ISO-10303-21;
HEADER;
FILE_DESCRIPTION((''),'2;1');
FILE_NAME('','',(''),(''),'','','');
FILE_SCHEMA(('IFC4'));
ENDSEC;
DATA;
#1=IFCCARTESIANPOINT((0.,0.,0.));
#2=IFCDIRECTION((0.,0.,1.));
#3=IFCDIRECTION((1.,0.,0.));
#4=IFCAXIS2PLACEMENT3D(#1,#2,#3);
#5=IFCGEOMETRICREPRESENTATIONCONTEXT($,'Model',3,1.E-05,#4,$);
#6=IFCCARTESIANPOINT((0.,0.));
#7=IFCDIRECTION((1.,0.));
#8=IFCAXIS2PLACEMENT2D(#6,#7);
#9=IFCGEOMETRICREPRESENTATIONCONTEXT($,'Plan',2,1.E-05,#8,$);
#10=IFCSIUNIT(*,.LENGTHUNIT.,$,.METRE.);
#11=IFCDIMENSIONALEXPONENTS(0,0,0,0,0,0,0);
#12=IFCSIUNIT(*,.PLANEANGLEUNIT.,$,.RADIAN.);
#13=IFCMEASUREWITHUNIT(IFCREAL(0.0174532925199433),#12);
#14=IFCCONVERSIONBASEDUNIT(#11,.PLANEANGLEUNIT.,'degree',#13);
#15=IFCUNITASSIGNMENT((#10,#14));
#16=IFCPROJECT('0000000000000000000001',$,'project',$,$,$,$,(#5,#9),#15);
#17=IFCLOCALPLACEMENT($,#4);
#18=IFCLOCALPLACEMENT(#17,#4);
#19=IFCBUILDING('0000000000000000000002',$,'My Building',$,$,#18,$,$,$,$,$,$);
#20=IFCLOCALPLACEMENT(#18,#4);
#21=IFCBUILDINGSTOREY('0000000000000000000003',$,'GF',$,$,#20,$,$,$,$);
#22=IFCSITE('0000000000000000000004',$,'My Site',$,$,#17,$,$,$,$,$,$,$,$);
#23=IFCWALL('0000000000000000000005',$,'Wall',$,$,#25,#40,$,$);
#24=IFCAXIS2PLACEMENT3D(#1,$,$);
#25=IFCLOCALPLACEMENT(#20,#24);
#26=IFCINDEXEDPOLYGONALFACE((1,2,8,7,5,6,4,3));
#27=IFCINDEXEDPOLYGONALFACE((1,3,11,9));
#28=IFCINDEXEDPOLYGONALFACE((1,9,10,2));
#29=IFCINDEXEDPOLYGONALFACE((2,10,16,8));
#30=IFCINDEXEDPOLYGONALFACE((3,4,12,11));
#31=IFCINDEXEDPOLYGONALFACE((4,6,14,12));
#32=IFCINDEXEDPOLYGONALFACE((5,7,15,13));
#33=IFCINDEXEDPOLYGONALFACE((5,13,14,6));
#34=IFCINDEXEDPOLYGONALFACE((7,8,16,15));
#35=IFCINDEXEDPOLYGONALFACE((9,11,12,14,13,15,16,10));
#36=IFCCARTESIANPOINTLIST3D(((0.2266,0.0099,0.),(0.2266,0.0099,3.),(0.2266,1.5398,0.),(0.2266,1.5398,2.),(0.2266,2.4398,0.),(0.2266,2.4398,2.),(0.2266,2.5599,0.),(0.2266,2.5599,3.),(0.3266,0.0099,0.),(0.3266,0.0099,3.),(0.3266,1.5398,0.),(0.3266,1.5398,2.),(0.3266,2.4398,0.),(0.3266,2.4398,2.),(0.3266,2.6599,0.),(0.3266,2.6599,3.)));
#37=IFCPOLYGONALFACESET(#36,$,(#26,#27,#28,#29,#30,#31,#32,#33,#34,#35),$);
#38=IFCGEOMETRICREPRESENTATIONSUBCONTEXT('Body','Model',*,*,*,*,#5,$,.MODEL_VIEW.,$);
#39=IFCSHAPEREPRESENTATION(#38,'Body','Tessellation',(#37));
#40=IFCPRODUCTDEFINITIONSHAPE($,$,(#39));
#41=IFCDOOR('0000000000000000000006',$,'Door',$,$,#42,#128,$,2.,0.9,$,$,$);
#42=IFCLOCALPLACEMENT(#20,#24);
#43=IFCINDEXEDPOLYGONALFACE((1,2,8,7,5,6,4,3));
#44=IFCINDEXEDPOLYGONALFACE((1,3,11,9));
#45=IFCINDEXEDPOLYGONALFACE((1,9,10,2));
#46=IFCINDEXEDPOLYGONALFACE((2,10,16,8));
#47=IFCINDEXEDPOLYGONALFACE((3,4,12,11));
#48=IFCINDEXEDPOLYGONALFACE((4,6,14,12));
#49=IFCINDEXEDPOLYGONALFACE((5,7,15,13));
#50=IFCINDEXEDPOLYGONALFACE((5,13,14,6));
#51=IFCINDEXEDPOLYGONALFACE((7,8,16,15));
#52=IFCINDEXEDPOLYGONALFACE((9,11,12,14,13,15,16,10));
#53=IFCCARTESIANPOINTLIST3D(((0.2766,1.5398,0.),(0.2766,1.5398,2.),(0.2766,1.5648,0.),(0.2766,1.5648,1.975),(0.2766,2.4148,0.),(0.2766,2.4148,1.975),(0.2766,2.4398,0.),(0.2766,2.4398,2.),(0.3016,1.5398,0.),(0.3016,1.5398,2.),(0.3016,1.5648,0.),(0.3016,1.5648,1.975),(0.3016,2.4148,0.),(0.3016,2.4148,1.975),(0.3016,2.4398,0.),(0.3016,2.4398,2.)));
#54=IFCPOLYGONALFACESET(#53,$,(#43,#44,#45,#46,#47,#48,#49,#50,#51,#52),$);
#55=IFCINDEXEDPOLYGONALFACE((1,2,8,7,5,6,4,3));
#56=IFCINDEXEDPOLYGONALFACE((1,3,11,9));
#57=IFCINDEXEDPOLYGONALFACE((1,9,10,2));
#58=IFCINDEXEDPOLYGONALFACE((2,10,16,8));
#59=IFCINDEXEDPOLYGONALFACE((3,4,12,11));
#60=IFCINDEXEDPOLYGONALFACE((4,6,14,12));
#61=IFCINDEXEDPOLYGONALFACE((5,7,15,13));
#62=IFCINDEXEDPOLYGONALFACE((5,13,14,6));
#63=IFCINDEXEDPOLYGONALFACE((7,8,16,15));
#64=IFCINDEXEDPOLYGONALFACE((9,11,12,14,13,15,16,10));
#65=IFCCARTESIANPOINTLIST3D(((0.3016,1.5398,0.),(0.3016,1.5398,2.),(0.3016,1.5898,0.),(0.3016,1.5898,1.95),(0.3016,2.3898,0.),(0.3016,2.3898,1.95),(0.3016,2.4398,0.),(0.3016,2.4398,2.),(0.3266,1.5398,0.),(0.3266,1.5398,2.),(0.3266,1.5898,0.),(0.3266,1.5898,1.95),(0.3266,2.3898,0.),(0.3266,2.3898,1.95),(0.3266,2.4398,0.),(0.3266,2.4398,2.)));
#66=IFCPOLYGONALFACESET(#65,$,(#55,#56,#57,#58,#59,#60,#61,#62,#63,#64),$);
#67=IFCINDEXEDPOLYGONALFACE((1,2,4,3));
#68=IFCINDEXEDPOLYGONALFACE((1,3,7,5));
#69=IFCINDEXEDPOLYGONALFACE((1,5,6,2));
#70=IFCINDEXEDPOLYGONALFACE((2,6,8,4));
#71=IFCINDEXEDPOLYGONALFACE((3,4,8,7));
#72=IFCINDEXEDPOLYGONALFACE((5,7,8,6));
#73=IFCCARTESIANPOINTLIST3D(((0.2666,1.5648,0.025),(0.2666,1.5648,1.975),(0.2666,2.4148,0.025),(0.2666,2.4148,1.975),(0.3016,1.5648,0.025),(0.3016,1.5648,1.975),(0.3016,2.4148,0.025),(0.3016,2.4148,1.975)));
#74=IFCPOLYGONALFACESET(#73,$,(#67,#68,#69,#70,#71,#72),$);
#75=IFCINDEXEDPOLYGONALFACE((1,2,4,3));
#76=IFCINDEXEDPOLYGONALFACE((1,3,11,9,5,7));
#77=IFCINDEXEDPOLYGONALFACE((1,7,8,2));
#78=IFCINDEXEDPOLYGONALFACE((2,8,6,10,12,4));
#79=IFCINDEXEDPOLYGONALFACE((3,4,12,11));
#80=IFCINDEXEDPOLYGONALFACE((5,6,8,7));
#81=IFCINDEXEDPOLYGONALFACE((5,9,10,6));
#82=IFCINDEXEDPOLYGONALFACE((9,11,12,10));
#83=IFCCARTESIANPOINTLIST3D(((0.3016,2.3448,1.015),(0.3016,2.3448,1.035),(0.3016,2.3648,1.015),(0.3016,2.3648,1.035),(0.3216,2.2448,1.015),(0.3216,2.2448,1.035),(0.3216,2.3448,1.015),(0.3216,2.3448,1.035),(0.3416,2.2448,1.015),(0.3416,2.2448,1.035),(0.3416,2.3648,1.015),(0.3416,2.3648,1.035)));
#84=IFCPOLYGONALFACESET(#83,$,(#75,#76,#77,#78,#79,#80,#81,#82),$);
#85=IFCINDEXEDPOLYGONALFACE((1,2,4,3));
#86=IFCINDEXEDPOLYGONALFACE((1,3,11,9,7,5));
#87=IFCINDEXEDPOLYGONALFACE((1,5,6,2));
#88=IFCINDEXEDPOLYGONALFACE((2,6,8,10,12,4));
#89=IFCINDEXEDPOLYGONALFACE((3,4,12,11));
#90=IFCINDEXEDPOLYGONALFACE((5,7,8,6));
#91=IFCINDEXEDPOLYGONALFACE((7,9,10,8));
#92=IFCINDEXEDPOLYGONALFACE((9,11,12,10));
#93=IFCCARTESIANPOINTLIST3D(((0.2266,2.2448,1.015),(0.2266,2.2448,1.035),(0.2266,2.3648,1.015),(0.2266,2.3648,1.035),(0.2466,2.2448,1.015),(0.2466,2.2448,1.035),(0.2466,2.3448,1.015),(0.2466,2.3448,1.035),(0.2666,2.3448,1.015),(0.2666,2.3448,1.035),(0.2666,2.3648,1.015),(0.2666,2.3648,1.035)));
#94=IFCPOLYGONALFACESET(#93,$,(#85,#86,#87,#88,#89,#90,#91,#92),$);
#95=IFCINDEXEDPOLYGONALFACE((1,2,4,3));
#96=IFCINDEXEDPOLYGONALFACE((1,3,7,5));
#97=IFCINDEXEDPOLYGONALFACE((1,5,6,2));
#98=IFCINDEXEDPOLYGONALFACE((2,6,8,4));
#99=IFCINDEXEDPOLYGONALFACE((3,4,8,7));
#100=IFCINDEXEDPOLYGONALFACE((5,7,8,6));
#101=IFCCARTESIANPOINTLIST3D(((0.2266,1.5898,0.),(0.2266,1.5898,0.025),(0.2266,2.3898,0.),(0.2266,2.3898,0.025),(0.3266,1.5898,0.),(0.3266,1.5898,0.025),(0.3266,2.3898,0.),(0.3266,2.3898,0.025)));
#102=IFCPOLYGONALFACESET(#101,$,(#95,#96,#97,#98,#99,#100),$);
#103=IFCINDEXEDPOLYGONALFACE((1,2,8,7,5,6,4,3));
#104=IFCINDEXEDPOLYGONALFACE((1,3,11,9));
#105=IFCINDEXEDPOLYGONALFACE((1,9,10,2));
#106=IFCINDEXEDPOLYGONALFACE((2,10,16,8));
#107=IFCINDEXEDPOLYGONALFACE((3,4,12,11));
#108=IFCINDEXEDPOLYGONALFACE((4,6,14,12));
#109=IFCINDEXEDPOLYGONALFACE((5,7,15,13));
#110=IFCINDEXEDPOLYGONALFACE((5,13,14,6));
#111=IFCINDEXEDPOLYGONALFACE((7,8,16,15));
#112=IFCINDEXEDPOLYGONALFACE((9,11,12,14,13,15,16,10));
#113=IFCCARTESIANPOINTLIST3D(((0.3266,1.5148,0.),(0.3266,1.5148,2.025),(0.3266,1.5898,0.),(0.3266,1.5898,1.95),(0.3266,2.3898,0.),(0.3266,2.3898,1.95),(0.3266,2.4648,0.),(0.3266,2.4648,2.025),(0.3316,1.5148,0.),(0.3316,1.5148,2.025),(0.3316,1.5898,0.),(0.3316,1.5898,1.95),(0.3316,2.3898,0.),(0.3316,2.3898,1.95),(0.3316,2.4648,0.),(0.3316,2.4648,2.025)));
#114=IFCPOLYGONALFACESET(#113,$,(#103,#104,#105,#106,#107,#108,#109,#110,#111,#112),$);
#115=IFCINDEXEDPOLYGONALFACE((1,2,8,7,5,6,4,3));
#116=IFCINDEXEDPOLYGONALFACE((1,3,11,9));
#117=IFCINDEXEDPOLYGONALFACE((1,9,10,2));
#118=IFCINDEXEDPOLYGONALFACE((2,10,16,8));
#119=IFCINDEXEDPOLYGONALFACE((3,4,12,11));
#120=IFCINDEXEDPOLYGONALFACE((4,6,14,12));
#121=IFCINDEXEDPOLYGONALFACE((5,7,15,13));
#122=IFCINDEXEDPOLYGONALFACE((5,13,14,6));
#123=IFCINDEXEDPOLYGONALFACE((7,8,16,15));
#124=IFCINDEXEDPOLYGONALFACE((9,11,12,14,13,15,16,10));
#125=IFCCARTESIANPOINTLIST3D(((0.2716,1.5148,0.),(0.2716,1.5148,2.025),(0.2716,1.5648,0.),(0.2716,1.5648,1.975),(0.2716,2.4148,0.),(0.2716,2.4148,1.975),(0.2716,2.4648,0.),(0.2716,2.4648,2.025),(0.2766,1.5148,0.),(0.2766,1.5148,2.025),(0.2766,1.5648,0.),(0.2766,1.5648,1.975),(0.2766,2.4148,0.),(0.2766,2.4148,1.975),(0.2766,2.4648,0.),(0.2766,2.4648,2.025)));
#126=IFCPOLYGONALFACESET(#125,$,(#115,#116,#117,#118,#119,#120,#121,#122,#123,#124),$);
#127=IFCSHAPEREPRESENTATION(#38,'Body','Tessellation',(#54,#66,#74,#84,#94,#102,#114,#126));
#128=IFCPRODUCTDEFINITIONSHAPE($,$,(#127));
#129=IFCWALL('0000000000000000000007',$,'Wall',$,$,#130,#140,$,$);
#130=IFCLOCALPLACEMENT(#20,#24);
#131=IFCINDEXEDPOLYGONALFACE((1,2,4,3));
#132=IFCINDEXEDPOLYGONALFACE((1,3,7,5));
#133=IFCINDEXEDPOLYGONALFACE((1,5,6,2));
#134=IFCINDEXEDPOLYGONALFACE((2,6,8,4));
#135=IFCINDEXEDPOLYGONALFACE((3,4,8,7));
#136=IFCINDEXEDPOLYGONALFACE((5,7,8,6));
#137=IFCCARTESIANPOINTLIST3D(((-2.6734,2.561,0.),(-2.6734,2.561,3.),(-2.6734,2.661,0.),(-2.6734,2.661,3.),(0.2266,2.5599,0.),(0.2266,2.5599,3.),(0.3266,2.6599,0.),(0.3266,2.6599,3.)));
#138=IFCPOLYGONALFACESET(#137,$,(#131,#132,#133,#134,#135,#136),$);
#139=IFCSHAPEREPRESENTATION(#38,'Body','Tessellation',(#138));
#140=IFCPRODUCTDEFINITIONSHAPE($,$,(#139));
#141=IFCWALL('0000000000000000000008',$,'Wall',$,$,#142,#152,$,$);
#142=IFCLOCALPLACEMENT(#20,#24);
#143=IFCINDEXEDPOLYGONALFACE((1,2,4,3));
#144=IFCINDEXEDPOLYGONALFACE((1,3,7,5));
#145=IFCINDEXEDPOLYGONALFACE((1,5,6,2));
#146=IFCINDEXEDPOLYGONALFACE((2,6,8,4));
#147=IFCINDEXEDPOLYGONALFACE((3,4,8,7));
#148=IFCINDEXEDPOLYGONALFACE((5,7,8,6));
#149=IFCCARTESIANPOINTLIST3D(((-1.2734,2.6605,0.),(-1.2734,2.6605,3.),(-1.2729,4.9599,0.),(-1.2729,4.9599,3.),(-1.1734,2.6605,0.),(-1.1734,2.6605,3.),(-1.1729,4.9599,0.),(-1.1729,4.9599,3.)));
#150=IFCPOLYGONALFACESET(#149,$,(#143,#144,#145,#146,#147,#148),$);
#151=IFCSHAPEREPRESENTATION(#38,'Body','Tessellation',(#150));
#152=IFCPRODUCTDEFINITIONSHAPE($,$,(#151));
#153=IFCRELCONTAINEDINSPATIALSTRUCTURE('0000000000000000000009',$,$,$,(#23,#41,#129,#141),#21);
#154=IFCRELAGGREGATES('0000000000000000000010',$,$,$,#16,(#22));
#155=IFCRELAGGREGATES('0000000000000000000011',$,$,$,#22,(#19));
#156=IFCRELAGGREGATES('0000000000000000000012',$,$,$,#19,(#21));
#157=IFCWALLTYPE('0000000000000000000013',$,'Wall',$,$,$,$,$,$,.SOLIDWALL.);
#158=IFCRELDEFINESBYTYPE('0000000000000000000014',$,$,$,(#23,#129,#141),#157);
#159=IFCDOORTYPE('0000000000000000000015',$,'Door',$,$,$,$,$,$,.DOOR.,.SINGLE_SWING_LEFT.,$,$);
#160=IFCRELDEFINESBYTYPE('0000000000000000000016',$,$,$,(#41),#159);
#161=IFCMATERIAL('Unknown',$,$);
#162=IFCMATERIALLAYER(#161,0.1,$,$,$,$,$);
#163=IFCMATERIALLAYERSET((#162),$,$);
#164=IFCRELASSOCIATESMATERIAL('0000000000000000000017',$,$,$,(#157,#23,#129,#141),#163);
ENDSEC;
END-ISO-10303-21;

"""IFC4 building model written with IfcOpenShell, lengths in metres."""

from ifc_helpers import new_model, entity, si_unit, converted_unit, frame, origin_with_axes, origin_2d_with_axis, place, context, subcontext, project, spatial, line, indexed_curve, outline, extrude, shape, source, transform, mapped, material, layer, layer_set, layer_usage, type_object, type_shapes, element, fill, save


model = new_model("IFC4")

# Units and contexts
model_context = context("Model", 3, precision=1e-05, world=origin_with_axes())
plan_context = context("Plan", 2, precision=1e-05, world=origin_2d_with_axis())
body_context_1 = subcontext(model_context, "Body", "Model", "MODEL_VIEW")
body_context_2 = subcontext(plan_context, "Body", "Plan", "PLAN_VIEW")
ifc_project = project(units=[si_unit("LENGTHUNIT", "METRE"), converted_unit("PLANEANGLEUNIT", "degree", entity("IfcReal", 0.0174532925199433), si_unit("PLANEANGLEUNIT", "RADIAN"), dimensions=[0, 0, 0, 0, 0, 0, 0])], contexts=[model_context, plan_context])

# Site, building, storey
site_placement = place(None, origin_with_axes())
site = spatial("IfcSite", under=ifc_project, at=site_placement, Name="My Site")
building_placement = place(site_placement, origin_with_axes())
building = spatial("IfcBuilding", under=site, at=building_placement, Name="My Building")
storey_placement = place(building_placement, origin_with_axes())
storey = spatial("IfcBuildingStorey", under=building, at=storey_placement, Name="GF")

# Shared definitions
ifc_material = material(Name="Unknown")

# Shared definitions
ifc_layer_1 = layer(ifc_material, 0.1)
ifc_layer_set_1 = layer_set([ifc_layer_1])
wall_type = type_object("IfcWallType", Name="Wall", PredefinedType="SOLIDWALL", material=ifc_layer_set_1)
shared_shape_1 = source(origin_with_axes(), body_context_1, "Body", "SweptSolid", [
    extrude(outline(indexed_curve([(0.0, 0.0), (0.9, 0.0), (0.9, 2.0), (0.0, 2.0)], segments=[line(1, 2, 3, 4, 1)])), frame((0.0, -0.6, 0.0), z_axis=(0.0, -1.0, 0.0), x_axis=(1.0, 0.0, 0.0)), (0.0, 0.0, -1.0), 1.2),
])
door_type = type_object("IfcDoorType", Name="Door", OperationType="SINGLE_SWING_LEFT", PredefinedType="DOOR")
shared_shape_2 = source(origin_with_axes(), body_context_1, "Body", "SweptSolid", [
    extrude(outline(indexed_curve([(0.0, 0.0), (0.0, 2.0), (0.9, 2.0), (0.9, 0.0), (0.875, 0.0), (0.875, 1.975), (0.025, 1.975), (0.025, 0.0)], segments=[line(1, 2, 3, 4, 5, 6, 7, 8, 1)])), frame((0.0, 0.025, 0.0), z_axis=(0.0, -1.0, 0.0), x_axis=(1.0, 0.0, 0.0)), (0.0, 0.0, -1.0), 0.025),
    extrude(outline(indexed_curve([(0.0, 0.0), (0.0, 2.0), (0.9, 2.0), (0.9, 0.0), (0.85, 0.0), (0.85, 1.95), (0.05, 1.95), (0.05, 0.0)], segments=[line(1, 2, 3, 4, 5, 6, 7, 8, 1)])), frame((0.0, 0.0, 0.0), z_axis=(0.0, -1.0, 0.0), x_axis=(1.0, 0.0, 0.0)), (0.0, 0.0, -1.0), 0.025),
    extrude(outline(indexed_curve([(0.0, 0.0), (0.85, 0.0), (0.85, 0.035), (0.0, 0.035)], segments=[line(1, 2, 3, 4, 1)])), frame((0.025, 0.025, 0.025), z_axis=(0.0, 0.0, 1.0), x_axis=(1.0, 0.0, 0.0)), (0.0, 0.0, 1.0), 1.95),
    extrude(outline(indexed_curve([(0.0, 0.0), (0.0, -0.04), (-0.12, -0.04), (-0.12, -0.02), (-0.02, -0.02), (-0.02, 0.0)], segments=[line(1, 2, 3, 4, 5, 6, 1)])), frame((0.825, 0.025, 1.015), z_axis=(0.0, 0.0, 1.0), x_axis=(1.0, 0.0, 0.0)), (0.0, 0.0, 1.0), 0.02),
    extrude(outline(indexed_curve([(0.0, 0.0), (0.0, 0.04), (-0.12, 0.04), (-0.12, 0.02), (-0.02, 0.02), (-0.02, 0.0)], segments=[line(1, 2, 3, 4, 5, 6, 1)])), frame((0.825, 0.06, 1.015), z_axis=(0.0, 0.0, 1.0), x_axis=(1.0, 0.0, 0.0)), (0.0, 0.0, 1.0), 0.02),
    extrude(outline(indexed_curve([(0.0, 0.0), (0.8, 0.0), (0.8, 0.1), (0.0, 0.1)], segments=[line(1, 2, 3, 4, 1)])), frame((0.05, 0.0, 0.0), z_axis=(0.0, 0.0, 1.0), x_axis=(1.0, 0.0, 0.0)), (0.0, 0.0, 1.0), 0.025),
    extrude(outline(indexed_curve([(0.0, 0.0), (0.0, 2.025), (0.95, 2.025), (0.95, 0.0), (0.875, 0.0), (0.875, 1.95), (0.075, 1.95), (0.075, 0.0)], segments=[line(1, 2, 3, 4, 5, 6, 7, 8, 1)])), frame((-0.025, -0.005, 0.0), z_axis=(0.0, -1.0, 0.0), x_axis=(1.0, 0.0, 0.0)), (0.0, 0.0, -1.0), 0.005),
    extrude(outline(indexed_curve([(0.0, 0.0), (0.0, 2.025), (0.95, 2.025), (0.95, 0.0), (0.9, 0.0), (0.9, 1.975), (0.05, 1.975), (0.05, 0.0)], segments=[line(1, 2, 3, 4, 5, 6, 7, 8, 1)])), frame((-0.025, 0.05, 0.0), z_axis=(0.0, -1.0, 0.0), x_axis=(1.0, 0.0, 0.0)), (0.0, 0.0, -1.0), 0.005),
])
shared_shape_3 = source(origin_with_axes(), body_context_2, "Body", "Curve2D", [
    entity("IfcIndexedPolyCurve", entity("IfcCartesianPointList2D", [[0.0, 0.0], [0.0, 0.05], [0.025, 0.05], [0.025, 0.025], [0.05, 0.025], [0.05, 0.0]]), [entity("IfcLineIndex", [1, 2, 3, 4, 5, 6, 1])]),
    entity("IfcIndexedPolyCurve", entity("IfcCartesianPointList2D", [[0.9, 0.0], [0.9, 0.05], [0.875, 0.05], [0.875, 0.025], [0.85, 0.025], [0.85, 0.0]]), [entity("IfcLineIndex", [1, 2, 3, 4, 5, 6, 1])]),
    entity("IfcTrimmedCurve", entity("IfcEllipse", entity("IfcAxis2Placement2D", entity("IfcCartesianPoint", [0.06, 0.05]), entity("IfcDirection", [1.0, 0.0])), 0.815, 0.85), [entity("IfcCartesianPoint", [0.875, 0.05])], [entity("IfcCartesianPoint", [0.06, 0.9])], True, "CARTESIAN"),
    entity("IfcIndexedPolyCurve", entity("IfcCartesianPointList2D", [[0.025, 0.05], [0.06, 0.05], [0.06, 0.9], [0.025, 0.9]]), [entity("IfcLineIndex", [1, 2, 3, 4, 1])]),
])
type_shapes(door_type, [shared_shape_2, shared_shape_3])

# Wall, opening, door
ifc_layer_usage_1 = layer_usage(ifc_layer_set_1, "AXIS2", "POSITIVE", 0.0)
wall_1_placement = place(storey_placement, frame((0.3266, 0.0099, 0.0), z_axis=(0.0, 0.0, 1.0), x_axis=(0.0, 1.0, 0.0)))
wall_1 = element("IfcWall", 1, at=wall_1_placement, inside=storey, type_object=wall_type, material=ifc_layer_usage_1, Name="Wall", context=body_context_1, shape_type="SweptSolid", body=[
    extrude(outline(indexed_curve([(0.0, 0.0), (0.0, 0.1), (2.55, 0.1), (2.65, 0.0)], segments=[line(1, 2, 3, 4, 1)])), origin_with_axes(), (0.0, 0.0, 1.0), 3.0),
])
opening_1_placement = place(wall_1_placement, frame((1.5299, 0.0, 0.0), z_axis=(0.0, 0.0, 1.0), x_axis=(1.0, 0.0, 0.0)))
opening_1 = element("IfcOpeningElement", 2, at=opening_1_placement, cuts=wall_1, PredefinedType="OPENING", context=body_context_1, shape_type="MappedRepresentation", body=[
    mapped(shared_shape_1, transform((0.0, 0.0, 0.0), x_axis=(1.0, 0.0, 0.0), y_axis=(0.0, 1.0, 0.0), z_axis=(0.0, 0.0, 1.0), scale=1.0)),
])
door_1_placement = place(opening_1_placement, frame((0.0, 0.0, 0.0), z_axis=(0.0, 0.0, 1.0), x_axis=(1.0, 0.0, 0.0)))
door_1 = element("IfcDoor", 3, at=door_1_placement, inside=storey, type_object=door_type, Name="Door", OverallHeight=2.0, OverallWidth=0.9, shapes=[
    shape(body_context_1, "Body", "MappedRepresentation", [mapped(shared_shape_2, transform((0.0, 0.0, 0.0), x_axis=(1.0, 0.0, 0.0), y_axis=(0.0, 1.0, 0.0), z_axis=(0.0, 0.0, 1.0), scale=1.0))]),
    shape(body_context_2, "Body", "MappedRepresentation", [mapped(shared_shape_3, transform((0.0, 0.0, 0.0), x_axis=(1.0, 0.0, 0.0), y_axis=(0.0, 1.0, 0.0), z_axis=(0.0, 0.0, 1.0), scale=1.0))]),
])
fill(opening_1, door_1)

# Walls
ifc_layer_usage_2 = layer_usage(ifc_layer_set_1, "AXIS2", "POSITIVE", 0.0)
wall_2_placement = place(storey_placement, frame((0.3266, 2.6599, 0.0), z_axis=(0.0, 0.0, 1.0), x_axis=(-1.0, 0.000381, 0.0)))
element("IfcWall", 4, at=wall_2_placement, inside=storey, type_object=wall_type, material=ifc_layer_usage_2, Name="Wall", context=body_context_1, shape_type="SweptSolid", body=[
    extrude(outline(indexed_curve([(0.0, 0.0), (0.1, 0.1), (3.0, 0.1), (3.0, 0.0)], segments=[line(1, 2, 3, 4, 1)])), origin_with_axes(), (0.0, 0.0, 1.0), 3.0),
])
ifc_layer_usage_3 = layer_usage(ifc_layer_set_1, "AXIS2", "POSITIVE", 0.0)
wall_3_placement = place(storey_placement, frame((-1.1734, 2.6605, 0.0), z_axis=(0.0, 0.0, 1.0), x_axis=(0.000197, 1.0, 0.0)))
element("IfcWall", 5, at=wall_3_placement, inside=storey, type_object=wall_type, material=ifc_layer_usage_3, Name="Wall", context=body_context_1, shape_type="SweptSolid", body=[
    extrude(outline(indexed_curve([(0.0, 0.0), (0.0, 0.1), (2.2994, 0.1), (2.2994, 0.0)], segments=[line(1, 2, 3, 4, 1)])), origin_with_axes(), (0.0, 0.0, 1.0), 3.0),
])

save(model, "model.ifc")
